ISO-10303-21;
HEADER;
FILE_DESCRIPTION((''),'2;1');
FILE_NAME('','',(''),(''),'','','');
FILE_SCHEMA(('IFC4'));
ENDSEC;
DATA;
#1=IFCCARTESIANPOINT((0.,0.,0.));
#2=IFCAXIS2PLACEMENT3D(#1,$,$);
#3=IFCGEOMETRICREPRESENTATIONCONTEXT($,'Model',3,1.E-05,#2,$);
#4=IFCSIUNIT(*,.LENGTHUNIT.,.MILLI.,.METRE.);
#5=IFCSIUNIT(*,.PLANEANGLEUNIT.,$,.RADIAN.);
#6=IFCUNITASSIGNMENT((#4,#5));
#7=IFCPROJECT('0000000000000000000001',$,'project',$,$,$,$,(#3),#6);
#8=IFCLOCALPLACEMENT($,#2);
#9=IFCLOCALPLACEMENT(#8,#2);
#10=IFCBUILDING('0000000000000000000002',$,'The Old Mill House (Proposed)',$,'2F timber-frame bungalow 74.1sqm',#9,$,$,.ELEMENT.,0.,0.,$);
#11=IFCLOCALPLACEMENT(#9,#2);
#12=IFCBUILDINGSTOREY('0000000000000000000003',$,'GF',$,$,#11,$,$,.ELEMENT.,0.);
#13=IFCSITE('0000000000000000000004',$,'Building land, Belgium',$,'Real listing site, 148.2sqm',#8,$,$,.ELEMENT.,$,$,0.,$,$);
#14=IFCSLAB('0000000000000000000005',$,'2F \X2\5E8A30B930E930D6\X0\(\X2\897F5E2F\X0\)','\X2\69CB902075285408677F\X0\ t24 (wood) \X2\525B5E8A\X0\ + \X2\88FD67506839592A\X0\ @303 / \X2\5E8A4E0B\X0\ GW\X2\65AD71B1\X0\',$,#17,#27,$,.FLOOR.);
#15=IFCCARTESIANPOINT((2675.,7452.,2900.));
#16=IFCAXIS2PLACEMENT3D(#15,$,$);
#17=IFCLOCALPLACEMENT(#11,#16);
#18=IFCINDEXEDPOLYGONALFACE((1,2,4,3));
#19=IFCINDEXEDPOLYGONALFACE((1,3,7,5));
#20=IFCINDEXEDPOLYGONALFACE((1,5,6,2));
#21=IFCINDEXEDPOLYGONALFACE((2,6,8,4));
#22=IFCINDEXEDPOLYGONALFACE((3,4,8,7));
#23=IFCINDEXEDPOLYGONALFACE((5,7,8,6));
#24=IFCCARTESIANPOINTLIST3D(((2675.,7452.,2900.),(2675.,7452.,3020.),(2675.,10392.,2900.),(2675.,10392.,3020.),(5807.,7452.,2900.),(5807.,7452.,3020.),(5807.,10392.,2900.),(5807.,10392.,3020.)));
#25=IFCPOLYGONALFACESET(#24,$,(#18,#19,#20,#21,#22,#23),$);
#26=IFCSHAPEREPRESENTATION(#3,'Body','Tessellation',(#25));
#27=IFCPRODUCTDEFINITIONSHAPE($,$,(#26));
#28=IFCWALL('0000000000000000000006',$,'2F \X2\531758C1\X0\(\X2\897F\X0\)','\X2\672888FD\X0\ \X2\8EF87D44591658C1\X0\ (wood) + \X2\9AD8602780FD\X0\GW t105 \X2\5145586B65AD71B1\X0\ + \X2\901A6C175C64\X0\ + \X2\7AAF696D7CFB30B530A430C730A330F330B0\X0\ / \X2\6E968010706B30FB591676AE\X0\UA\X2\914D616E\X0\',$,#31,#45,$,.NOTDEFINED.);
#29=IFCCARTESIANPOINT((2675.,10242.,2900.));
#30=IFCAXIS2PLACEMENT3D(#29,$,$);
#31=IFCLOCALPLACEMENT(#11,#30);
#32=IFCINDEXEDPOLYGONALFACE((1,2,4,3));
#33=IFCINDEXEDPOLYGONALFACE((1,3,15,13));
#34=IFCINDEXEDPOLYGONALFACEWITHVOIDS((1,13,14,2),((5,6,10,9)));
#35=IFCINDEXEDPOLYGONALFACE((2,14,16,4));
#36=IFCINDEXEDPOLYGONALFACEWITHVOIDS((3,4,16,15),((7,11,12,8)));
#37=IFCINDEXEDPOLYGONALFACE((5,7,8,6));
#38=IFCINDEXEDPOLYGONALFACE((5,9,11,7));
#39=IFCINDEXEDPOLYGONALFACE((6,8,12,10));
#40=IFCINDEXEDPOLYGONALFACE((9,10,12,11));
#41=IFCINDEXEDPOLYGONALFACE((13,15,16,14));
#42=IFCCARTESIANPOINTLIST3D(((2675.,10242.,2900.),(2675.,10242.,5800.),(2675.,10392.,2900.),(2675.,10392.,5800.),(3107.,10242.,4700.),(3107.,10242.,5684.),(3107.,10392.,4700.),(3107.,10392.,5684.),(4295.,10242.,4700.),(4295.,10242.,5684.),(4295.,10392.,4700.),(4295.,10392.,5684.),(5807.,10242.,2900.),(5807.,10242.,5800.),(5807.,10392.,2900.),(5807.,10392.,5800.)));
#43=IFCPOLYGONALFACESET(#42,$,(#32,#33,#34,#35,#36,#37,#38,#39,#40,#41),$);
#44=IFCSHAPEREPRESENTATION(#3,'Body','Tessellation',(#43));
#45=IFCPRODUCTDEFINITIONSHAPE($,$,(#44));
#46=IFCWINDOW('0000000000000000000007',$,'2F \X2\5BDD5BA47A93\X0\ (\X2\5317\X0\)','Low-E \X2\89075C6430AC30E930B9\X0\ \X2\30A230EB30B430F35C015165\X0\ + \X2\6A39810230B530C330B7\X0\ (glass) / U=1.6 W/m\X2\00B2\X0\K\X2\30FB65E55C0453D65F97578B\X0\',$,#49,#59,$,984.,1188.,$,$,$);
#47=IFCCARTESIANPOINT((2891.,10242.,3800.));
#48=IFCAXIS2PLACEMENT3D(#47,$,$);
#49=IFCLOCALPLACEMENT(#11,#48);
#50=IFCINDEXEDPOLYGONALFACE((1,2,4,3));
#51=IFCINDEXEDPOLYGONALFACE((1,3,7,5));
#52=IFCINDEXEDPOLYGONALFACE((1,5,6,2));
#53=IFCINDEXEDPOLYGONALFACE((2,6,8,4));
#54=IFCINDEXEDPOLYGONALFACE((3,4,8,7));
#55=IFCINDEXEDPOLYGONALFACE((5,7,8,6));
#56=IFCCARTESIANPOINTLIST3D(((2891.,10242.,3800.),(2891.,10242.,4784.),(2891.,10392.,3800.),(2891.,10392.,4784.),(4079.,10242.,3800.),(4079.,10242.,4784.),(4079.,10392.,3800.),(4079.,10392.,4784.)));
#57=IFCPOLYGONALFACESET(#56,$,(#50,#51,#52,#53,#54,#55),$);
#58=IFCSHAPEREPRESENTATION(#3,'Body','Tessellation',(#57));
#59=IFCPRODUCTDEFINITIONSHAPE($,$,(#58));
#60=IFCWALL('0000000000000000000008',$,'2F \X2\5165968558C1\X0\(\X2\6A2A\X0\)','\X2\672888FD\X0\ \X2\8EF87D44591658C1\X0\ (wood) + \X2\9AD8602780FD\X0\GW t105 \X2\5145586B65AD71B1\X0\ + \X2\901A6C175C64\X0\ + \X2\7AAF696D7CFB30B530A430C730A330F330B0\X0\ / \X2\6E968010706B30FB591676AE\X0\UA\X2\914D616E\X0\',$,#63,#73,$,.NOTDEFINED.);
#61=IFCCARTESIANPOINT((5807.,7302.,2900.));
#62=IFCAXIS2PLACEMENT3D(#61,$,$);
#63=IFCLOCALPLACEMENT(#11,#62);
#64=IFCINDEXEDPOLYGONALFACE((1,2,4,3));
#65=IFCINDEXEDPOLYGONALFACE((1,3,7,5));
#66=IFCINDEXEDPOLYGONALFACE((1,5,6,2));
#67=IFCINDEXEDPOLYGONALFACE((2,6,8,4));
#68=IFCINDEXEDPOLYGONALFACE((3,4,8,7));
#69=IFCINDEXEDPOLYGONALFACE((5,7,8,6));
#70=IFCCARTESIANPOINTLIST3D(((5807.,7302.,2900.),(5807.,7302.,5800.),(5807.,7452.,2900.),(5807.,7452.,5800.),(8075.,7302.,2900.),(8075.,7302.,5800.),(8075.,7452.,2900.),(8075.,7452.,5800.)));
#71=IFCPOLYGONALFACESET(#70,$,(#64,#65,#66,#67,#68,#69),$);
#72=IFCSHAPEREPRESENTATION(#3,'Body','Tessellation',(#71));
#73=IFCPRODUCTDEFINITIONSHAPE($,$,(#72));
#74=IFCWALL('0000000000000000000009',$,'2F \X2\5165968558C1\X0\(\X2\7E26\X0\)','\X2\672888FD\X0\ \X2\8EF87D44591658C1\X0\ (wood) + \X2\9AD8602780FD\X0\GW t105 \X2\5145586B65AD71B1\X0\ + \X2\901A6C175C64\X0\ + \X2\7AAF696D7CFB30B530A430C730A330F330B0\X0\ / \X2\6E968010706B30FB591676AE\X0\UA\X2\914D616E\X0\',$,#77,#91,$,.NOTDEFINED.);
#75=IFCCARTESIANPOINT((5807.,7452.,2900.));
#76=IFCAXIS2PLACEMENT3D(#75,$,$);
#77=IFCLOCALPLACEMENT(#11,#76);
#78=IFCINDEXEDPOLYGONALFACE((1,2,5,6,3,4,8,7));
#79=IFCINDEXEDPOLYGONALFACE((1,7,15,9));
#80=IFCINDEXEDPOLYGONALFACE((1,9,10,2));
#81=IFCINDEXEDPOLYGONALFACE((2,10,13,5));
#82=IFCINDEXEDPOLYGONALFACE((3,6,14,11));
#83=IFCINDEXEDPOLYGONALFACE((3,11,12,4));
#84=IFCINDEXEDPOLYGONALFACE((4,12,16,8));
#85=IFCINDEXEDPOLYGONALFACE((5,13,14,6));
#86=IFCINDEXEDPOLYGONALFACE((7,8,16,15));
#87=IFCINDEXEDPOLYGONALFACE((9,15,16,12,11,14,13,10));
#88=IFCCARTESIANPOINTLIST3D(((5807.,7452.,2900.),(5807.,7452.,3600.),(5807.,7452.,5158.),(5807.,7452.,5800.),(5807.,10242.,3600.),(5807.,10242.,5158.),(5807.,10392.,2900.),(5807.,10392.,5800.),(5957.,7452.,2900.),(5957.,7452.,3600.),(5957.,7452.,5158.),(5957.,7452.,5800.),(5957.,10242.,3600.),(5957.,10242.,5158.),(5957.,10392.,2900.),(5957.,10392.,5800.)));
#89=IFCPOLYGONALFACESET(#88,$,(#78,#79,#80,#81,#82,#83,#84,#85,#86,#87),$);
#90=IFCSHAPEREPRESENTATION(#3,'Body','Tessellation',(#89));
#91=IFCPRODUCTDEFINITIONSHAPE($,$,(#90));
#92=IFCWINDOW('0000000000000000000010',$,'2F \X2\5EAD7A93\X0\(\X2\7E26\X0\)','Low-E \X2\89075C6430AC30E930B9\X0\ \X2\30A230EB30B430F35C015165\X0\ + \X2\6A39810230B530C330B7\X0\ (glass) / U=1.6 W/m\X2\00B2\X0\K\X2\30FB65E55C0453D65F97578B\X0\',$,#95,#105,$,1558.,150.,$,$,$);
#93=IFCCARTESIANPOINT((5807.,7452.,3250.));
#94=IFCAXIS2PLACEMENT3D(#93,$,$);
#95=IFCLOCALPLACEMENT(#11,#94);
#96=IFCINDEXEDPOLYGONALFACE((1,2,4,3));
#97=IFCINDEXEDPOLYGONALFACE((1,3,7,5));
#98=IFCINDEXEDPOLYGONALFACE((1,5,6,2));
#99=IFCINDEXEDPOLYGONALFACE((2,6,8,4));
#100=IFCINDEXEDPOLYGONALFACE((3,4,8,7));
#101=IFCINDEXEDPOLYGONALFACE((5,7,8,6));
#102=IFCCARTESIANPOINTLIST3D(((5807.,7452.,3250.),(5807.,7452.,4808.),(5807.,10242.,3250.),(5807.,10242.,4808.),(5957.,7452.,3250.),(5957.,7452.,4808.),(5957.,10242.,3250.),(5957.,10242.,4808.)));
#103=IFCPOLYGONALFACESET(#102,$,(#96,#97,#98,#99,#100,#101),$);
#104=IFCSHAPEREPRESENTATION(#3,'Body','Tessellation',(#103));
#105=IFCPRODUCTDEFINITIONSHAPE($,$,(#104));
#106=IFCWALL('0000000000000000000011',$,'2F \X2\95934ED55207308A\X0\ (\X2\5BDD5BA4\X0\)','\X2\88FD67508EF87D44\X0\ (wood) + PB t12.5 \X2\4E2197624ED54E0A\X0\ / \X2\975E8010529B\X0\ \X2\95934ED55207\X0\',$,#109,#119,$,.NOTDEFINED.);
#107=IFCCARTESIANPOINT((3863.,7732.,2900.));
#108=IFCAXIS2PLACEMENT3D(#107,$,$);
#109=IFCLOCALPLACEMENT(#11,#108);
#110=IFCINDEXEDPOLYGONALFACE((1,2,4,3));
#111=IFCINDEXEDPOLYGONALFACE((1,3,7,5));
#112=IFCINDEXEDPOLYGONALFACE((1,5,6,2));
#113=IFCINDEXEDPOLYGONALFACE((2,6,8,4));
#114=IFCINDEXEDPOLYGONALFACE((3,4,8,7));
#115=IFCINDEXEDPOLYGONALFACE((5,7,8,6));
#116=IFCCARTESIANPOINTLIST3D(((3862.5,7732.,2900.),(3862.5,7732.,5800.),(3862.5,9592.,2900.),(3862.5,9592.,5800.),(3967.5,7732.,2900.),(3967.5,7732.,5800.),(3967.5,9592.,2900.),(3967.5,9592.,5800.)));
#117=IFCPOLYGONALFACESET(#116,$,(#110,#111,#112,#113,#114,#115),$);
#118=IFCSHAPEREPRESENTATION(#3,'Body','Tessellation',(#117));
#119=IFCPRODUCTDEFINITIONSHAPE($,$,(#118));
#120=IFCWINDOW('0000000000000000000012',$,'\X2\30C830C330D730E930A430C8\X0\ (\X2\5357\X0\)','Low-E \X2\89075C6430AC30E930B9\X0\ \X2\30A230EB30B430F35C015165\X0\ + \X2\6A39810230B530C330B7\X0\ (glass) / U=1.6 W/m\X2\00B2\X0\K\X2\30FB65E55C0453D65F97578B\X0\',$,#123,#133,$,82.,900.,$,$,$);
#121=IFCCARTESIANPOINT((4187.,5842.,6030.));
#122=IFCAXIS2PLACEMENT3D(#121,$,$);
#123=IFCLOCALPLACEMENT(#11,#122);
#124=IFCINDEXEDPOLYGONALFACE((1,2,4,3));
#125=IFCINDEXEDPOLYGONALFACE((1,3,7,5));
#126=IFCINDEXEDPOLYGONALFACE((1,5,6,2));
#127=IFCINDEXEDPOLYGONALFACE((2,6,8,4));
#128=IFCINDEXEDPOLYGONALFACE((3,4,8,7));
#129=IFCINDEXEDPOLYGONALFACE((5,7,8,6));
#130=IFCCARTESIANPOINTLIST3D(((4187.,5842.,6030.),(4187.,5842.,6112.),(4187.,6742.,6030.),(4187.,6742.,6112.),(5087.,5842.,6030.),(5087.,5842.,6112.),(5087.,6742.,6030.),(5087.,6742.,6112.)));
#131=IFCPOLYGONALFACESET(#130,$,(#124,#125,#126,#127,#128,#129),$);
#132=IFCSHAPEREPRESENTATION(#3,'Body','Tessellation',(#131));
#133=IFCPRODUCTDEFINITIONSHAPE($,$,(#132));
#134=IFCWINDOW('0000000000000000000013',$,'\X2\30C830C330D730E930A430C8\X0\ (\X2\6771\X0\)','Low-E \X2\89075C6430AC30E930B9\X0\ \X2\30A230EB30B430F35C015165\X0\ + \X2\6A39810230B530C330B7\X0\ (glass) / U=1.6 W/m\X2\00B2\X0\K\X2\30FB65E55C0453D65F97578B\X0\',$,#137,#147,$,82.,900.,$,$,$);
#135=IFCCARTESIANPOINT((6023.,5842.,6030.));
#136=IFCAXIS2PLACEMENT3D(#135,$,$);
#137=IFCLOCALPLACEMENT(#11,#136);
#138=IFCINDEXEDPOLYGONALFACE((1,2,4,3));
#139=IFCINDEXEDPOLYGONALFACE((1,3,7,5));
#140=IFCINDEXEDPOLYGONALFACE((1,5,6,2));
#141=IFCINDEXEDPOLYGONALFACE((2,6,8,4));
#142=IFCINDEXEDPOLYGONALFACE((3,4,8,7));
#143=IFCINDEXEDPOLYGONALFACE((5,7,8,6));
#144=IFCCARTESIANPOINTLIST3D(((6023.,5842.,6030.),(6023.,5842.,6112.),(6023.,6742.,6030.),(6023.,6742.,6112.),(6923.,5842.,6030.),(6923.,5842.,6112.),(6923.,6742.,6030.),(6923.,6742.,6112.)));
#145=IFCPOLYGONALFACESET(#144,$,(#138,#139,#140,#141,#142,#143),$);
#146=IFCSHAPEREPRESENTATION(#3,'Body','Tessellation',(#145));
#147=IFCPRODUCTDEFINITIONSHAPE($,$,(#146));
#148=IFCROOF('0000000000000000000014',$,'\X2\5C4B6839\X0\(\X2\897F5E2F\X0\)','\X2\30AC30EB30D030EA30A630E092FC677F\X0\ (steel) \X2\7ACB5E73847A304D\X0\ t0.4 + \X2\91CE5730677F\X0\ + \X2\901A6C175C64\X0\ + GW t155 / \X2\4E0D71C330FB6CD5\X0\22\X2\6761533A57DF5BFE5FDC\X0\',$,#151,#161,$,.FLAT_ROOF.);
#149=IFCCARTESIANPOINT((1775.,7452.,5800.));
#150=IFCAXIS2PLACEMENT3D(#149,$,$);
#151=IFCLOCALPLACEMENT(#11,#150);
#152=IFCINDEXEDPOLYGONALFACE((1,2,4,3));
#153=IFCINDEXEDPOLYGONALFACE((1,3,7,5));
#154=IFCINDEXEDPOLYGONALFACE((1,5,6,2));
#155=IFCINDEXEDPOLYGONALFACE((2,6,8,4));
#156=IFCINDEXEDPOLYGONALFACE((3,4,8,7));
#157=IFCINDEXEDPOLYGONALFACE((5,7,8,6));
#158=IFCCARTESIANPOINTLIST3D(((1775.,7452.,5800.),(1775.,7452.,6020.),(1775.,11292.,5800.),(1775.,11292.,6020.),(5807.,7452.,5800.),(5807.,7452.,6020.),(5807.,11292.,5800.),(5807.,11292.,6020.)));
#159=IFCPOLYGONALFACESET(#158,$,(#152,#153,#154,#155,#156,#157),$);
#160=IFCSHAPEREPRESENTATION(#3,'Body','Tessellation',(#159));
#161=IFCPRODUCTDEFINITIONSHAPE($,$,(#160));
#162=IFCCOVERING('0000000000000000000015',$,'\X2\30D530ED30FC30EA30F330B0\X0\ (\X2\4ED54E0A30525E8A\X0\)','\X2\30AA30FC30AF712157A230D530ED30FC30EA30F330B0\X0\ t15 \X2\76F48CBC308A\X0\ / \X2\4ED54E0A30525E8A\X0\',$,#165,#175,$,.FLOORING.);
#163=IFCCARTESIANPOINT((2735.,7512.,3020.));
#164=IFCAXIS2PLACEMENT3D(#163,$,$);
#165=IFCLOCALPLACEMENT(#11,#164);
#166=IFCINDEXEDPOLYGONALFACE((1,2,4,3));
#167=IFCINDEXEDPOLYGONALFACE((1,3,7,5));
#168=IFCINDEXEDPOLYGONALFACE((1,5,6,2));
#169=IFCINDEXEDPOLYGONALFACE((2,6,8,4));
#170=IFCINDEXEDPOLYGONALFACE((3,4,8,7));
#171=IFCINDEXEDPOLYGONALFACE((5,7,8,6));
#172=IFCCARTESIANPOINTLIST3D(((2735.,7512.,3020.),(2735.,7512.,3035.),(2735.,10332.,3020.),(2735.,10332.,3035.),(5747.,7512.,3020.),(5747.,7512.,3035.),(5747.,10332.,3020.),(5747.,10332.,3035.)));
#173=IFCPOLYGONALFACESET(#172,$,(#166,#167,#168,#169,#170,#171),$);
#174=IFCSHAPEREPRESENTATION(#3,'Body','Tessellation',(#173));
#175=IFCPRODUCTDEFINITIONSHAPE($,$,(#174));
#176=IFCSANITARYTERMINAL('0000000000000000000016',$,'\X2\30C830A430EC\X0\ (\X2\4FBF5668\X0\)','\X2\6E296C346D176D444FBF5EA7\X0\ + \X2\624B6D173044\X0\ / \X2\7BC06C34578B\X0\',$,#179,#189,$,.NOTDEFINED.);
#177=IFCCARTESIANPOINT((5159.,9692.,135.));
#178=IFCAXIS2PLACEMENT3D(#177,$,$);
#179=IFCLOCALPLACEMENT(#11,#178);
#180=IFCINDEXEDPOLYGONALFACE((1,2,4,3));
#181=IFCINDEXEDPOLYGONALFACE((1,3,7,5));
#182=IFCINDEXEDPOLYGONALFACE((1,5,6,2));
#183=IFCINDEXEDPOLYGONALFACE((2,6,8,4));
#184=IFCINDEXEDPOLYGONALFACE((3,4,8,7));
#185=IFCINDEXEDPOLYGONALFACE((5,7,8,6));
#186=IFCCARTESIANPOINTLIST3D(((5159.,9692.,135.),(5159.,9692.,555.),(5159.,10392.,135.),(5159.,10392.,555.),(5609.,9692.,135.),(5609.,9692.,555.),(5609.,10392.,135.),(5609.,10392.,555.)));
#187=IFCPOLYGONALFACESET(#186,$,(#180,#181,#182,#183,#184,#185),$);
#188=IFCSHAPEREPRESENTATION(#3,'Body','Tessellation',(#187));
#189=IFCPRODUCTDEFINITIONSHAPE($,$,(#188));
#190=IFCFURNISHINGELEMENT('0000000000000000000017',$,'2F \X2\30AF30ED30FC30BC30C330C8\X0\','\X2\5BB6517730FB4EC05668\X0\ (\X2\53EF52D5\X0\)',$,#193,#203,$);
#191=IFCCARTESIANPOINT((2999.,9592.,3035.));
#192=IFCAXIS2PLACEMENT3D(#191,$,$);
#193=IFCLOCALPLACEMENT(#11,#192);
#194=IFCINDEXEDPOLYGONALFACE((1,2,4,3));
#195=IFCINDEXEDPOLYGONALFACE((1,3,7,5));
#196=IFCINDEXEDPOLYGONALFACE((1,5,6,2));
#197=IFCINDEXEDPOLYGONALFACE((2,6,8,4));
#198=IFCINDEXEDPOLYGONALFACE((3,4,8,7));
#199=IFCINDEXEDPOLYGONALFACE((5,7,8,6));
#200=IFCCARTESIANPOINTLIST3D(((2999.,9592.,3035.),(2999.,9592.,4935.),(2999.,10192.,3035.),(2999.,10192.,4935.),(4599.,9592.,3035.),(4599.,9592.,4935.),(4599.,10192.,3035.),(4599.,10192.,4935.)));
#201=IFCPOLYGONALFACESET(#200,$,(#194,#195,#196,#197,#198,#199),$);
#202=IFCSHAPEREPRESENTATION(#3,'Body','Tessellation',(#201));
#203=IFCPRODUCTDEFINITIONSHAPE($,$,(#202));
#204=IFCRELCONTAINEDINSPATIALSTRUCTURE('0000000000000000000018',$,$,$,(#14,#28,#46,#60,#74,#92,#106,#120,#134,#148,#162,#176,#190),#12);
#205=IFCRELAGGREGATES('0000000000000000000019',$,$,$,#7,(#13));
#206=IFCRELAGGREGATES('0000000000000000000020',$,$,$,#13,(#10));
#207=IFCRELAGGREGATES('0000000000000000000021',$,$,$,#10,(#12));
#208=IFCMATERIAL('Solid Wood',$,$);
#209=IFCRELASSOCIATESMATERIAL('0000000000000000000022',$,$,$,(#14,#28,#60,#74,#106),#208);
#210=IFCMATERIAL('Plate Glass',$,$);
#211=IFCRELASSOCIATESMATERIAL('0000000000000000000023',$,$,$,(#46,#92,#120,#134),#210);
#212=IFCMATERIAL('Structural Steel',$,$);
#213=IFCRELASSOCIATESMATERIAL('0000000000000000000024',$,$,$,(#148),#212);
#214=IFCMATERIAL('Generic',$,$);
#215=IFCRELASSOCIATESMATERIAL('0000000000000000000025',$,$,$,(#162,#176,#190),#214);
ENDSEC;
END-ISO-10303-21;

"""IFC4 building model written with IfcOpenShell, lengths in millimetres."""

from ifc_helpers import new_model, si_unit, frame, frame_2d, origin, place, context, project, spatial, rectangle, extrude, material, element, fill, save


model = new_model("IFC4")

# Units and contexts
model_context = context("Model", 3, precision=1e-05, world=origin())
ifc_project = project(units=[si_unit("LENGTHUNIT", "METRE", prefix="MILLI"), si_unit("PLANEANGLEUNIT", "RADIAN")], contexts=[model_context])

# Site, building, storey
site_placement = place(None, origin())
site = spatial("IfcSite", under=ifc_project, at=site_placement, Name="Building land, Belgium", ObjectType="Real listing site, 148.2sqm", CompositionType="ELEMENT", RefElevation=0.0)
building_placement = place(site_placement, origin())
building = spatial("IfcBuilding", under=site, at=building_placement, Name="The Old Mill House (Proposed)", ObjectType="2F timber-frame bungalow 74.1sqm", CompositionType="ELEMENT", ElevationOfRefHeight=0.0, ElevationOfTerrain=0.0)
storey_placement = place(building_placement, origin())
storey = spatial("IfcBuildingStorey", under=building, at=storey_placement, Name="GF", CompositionType="ELEMENT", Elevation=0.0)

# Slab
ifc_material_1 = material(Name="Solid Wood")
slab_placement = place(storey_placement, frame((2675.0, 7452.0, 2900.0)))
element("IfcSlab", 1, at=slab_placement, inside=storey, material=ifc_material_1, Name="2F 床スラブ(西帯)", Description="構造用合板 t24 (wood) 剛床 + 製材根太 @303 / 床下 GW断熱", PredefinedType="FLOOR", context=model_context, shape_type="SweptSolid", body=[
    extrude(rectangle(XDim=3132.0, YDim=2940.0, at=frame_2d((1566.0, 1470.0))), frame((2675.0, 7452.0, 2900.0)), (0.0, 0.0, 1.0), 120.0),
])

# Wall, opening, window
wall_1_placement = place(storey_placement, frame((2675.0, 10242.0, 2900.0)))
wall_1 = element("IfcWall", 2, at=wall_1_placement, inside=storey, material=ifc_material_1, Name="2F 北壁(西)", Description="木製 軸組外壁 (wood) + 高性能GW t105 充填断熱 + 通気層 + 窯業系サイディング / 準耐火・外皮UA配慮", PredefinedType="NOTDEFINED", context=model_context, shape_type="SweptSolid", body=[
    extrude(rectangle(XDim=3132.0, YDim=150.0, at=frame_2d((1566.0, 75.0))), frame((2675.0, 10242.0, 2900.0)), (0.0, 0.0, 1.0), 2900.0),
])
opening_1_placement = place(storey_placement, frame((2891.0, 10242.0, 3800.0)))
opening_1 = element("IfcOpeningElement", 3, at=opening_1_placement, cuts=wall_1, PredefinedType="NOTDEFINED", context=model_context, shape_type="SweptSolid", body=[
    extrude(rectangle(XDim=1188.0, YDim=150.0, at=frame_2d((594.0, 75.0))), frame((2891.0, 10242.0, 3800.0)), (0.0, 0.0, 1.0), 984.0),
])
ifc_material_2 = material(Name="Plate Glass")
window_1_placement = place(storey_placement, frame((2891.0, 10242.0, 3800.0)))
window_1 = element("IfcWindow", 4, at=window_1_placement, inside=storey, material=ifc_material_2, Name="2F 寝室窓 (北)", Description="Low-E 複層ガラス アルゴン封入 + 樹脂サッシ (glass) / U=1.6 W/m²K・日射取得型", OverallHeight=984.0, OverallWidth=1188.0, context=model_context, shape_type="SweptSolid", body=[
    extrude(rectangle(XDim=1188.0, YDim=150.0, at=frame_2d((594.0, 75.0))), frame((2891.0, 10242.0, 3800.0)), (0.0, 0.0, 1.0), 984.0),
])
fill(opening_1, window_1)

# Wall
wall_2_placement = place(storey_placement, frame((5807.0, 7302.0, 2900.0)))
element("IfcWall", 5, at=wall_2_placement, inside=storey, material=ifc_material_1, Name="2F 入隅壁(横)", Description="木製 軸組外壁 (wood) + 高性能GW t105 充填断熱 + 通気層 + 窯業系サイディング / 準耐火・外皮UA配慮", PredefinedType="NOTDEFINED", context=model_context, shape_type="SweptSolid", body=[
    extrude(rectangle(XDim=2268.0, YDim=150.0, at=frame_2d((1134.0, 75.0))), frame((5807.0, 7302.0, 2900.0)), (0.0, 0.0, 1.0), 2900.0),
])

# Wall, opening, window
wall_3_placement = place(storey_placement, frame((5807.0, 7452.0, 2900.0)))
wall_3 = element("IfcWall", 6, at=wall_3_placement, inside=storey, material=ifc_material_1, Name="2F 入隅壁(縦)", Description="木製 軸組外壁 (wood) + 高性能GW t105 充填断熱 + 通気層 + 窯業系サイディング / 準耐火・外皮UA配慮", PredefinedType="NOTDEFINED", context=model_context, shape_type="SweptSolid", body=[
    extrude(rectangle(XDim=150.0, YDim=2940.0, at=frame_2d((75.0, 1470.0))), frame((5807.0, 7452.0, 2900.0)), (0.0, 0.0, 1.0), 2900.0),
])
opening_2_placement = place(storey_placement, frame((5807.0, 7452.0, 3250.0)))
opening_2 = element("IfcOpeningElement", 7, at=opening_2_placement, cuts=wall_3, PredefinedType="NOTDEFINED", context=model_context, shape_type="SweptSolid", body=[
    extrude(rectangle(XDim=150.0, YDim=2790.0, at=frame_2d((75.0, 1395.0))), frame((5807.0, 7452.0, 3250.0)), (0.0, 0.0, 1.0), 1558.0),
])
window_2_placement = place(storey_placement, frame((5807.0, 7452.0, 3250.0)))
window_2 = element("IfcWindow", 8, at=window_2_placement, inside=storey, material=ifc_material_2, Name="2F 庭窓(縦)", Description="Low-E 複層ガラス アルゴン封入 + 樹脂サッシ (glass) / U=1.6 W/m²K・日射取得型", OverallHeight=1558.0, OverallWidth=150.0, context=model_context, shape_type="SweptSolid", body=[
    extrude(rectangle(XDim=150.0, YDim=2790.0, at=frame_2d((75.0, 1395.0))), frame((5807.0, 7452.0, 3250.0)), (0.0, 0.0, 1.0), 1558.0),
])
fill(opening_2, window_2)

# Wall
wall_4_placement = place(storey_placement, frame((3863.0, 7732.0, 2900.0)))
element("IfcWall", 9, at=wall_4_placement, inside=storey, material=ifc_material_1, Name="2F 間仕切り (寝室)", Description="製材軸組 (wood) + PB t12.5 両面仕上 / 非耐力 間仕切", PredefinedType="NOTDEFINED", context=model_context, shape_type="SweptSolid", body=[
    extrude(rectangle(XDim=105.0, YDim=1860.0, at=frame_2d((52.0, 930.0))), frame((3863.0, 7732.0, 2900.0)), (0.0, 0.0, 1.0), 2900.0),
])

# Windows
window_3_placement = place(storey_placement, frame((4187.0, 5842.0, 6030.0)))
element("IfcWindow", 10, at=window_3_placement, inside=storey, material=ifc_material_2, Name="トップライト (南)", Description="Low-E 複層ガラス アルゴン封入 + 樹脂サッシ (glass) / U=1.6 W/m²K・日射取得型", OverallHeight=82.0, OverallWidth=900.0, context=model_context, shape_type="SweptSolid", body=[
    extrude(rectangle(XDim=900.0, YDim=900.0, at=frame_2d((450.0, 450.0))), frame((4187.0, 5842.0, 6030.0)), (0.0, 0.0, 1.0), 82.0),
])
window_4_placement = place(storey_placement, frame((6023.0, 5842.0, 6030.0)))
element("IfcWindow", 11, at=window_4_placement, inside=storey, material=ifc_material_2, Name="トップライト (東)", Description="Low-E 複層ガラス アルゴン封入 + 樹脂サッシ (glass) / U=1.6 W/m²K・日射取得型", OverallHeight=82.0, OverallWidth=900.0, context=model_context, shape_type="SweptSolid", body=[
    extrude(rectangle(XDim=900.0, YDim=900.0, at=frame_2d((450.0, 450.0))), frame((6023.0, 5842.0, 6030.0)), (0.0, 0.0, 1.0), 82.0),
])

# Roof
ifc_material_3 = material(Name="Structural Steel")
for number, where, name in (
    (12, (1775.0, 7452.0, 5800.0), "屋根(西帯)"),
):
    element("IfcRoof", number, at=place(storey_placement, frame(where)), inside=storey, material=ifc_material_3, Name=name, Description="ガルバリウム鋼板 (steel) 立平葺き t0.4 + 野地板 + 通気層 + GW t155 / 不燃・法22条区域対応", PredefinedType="FLAT_ROOF", context=model_context, shape_type="SweptSolid", body=[
        extrude(rectangle(XDim=4032.0, YDim=3840.0, at=frame_2d((2016.0, 1920.0))), frame((1775.0, 7452.0, 5800.0)), (0.0, 0.0, 1.0), 220.0),
    ])

# Covering
ifc_material_4 = material(Name="Generic")
covering_placement = place(storey_placement, frame((2735.0, 7512.0, 3020.0)))
element("IfcCovering", 13, at=covering_placement, inside=storey, material=ifc_material_4, Name="フローリング (仕上げ床)", Description="オーク無垢フローリング t15 直貼り / 仕上げ床", PredefinedType="FLOORING", context=model_context, shape_type="SweptSolid", body=[
    extrude(rectangle(XDim=3012.0, YDim=2820.0, at=frame_2d((1506.0, 1410.0))), frame((2735.0, 7512.0, 3020.0)), (0.0, 0.0, 1.0), 15.0),
])

# Sanitary terminal
sanitary_terminal_placement = place(storey_placement, frame((5159.0, 9692.0, 135.0)))
element("IfcSanitaryTerminal", 14, at=sanitary_terminal_placement, inside=storey, material=ifc_material_4, Name="トイレ (便器)", Description="温水洗浄便座 + 手洗い / 節水型", PredefinedType="NOTDEFINED", context=model_context, shape_type="SweptSolid", body=[
    extrude(rectangle(XDim=450.0, YDim=700.0, at=frame_2d((225.0, 350.0))), frame((5159.0, 9692.0, 135.0)), (0.0, 0.0, 1.0), 420.0),
])

# Furnishing element
furnishing_1_placement = place(storey_placement, frame((2999.0, 9592.0, 3035.0)))
element("IfcFurnishingElement", 15, at=furnishing_1_placement, inside=storey, material=ifc_material_4, Name="2F クローゼット", Description="家具・什器 (可動)", context=model_context, shape_type="SweptSolid", body=[
    extrude(rectangle(XDim=1600.0, YDim=600.0, at=frame_2d((800.0, 300.0))), frame((2999.0, 9592.0, 3035.0)), (0.0, 0.0, 1.0), 1900.0),
])

save(model, "model.ifc")
